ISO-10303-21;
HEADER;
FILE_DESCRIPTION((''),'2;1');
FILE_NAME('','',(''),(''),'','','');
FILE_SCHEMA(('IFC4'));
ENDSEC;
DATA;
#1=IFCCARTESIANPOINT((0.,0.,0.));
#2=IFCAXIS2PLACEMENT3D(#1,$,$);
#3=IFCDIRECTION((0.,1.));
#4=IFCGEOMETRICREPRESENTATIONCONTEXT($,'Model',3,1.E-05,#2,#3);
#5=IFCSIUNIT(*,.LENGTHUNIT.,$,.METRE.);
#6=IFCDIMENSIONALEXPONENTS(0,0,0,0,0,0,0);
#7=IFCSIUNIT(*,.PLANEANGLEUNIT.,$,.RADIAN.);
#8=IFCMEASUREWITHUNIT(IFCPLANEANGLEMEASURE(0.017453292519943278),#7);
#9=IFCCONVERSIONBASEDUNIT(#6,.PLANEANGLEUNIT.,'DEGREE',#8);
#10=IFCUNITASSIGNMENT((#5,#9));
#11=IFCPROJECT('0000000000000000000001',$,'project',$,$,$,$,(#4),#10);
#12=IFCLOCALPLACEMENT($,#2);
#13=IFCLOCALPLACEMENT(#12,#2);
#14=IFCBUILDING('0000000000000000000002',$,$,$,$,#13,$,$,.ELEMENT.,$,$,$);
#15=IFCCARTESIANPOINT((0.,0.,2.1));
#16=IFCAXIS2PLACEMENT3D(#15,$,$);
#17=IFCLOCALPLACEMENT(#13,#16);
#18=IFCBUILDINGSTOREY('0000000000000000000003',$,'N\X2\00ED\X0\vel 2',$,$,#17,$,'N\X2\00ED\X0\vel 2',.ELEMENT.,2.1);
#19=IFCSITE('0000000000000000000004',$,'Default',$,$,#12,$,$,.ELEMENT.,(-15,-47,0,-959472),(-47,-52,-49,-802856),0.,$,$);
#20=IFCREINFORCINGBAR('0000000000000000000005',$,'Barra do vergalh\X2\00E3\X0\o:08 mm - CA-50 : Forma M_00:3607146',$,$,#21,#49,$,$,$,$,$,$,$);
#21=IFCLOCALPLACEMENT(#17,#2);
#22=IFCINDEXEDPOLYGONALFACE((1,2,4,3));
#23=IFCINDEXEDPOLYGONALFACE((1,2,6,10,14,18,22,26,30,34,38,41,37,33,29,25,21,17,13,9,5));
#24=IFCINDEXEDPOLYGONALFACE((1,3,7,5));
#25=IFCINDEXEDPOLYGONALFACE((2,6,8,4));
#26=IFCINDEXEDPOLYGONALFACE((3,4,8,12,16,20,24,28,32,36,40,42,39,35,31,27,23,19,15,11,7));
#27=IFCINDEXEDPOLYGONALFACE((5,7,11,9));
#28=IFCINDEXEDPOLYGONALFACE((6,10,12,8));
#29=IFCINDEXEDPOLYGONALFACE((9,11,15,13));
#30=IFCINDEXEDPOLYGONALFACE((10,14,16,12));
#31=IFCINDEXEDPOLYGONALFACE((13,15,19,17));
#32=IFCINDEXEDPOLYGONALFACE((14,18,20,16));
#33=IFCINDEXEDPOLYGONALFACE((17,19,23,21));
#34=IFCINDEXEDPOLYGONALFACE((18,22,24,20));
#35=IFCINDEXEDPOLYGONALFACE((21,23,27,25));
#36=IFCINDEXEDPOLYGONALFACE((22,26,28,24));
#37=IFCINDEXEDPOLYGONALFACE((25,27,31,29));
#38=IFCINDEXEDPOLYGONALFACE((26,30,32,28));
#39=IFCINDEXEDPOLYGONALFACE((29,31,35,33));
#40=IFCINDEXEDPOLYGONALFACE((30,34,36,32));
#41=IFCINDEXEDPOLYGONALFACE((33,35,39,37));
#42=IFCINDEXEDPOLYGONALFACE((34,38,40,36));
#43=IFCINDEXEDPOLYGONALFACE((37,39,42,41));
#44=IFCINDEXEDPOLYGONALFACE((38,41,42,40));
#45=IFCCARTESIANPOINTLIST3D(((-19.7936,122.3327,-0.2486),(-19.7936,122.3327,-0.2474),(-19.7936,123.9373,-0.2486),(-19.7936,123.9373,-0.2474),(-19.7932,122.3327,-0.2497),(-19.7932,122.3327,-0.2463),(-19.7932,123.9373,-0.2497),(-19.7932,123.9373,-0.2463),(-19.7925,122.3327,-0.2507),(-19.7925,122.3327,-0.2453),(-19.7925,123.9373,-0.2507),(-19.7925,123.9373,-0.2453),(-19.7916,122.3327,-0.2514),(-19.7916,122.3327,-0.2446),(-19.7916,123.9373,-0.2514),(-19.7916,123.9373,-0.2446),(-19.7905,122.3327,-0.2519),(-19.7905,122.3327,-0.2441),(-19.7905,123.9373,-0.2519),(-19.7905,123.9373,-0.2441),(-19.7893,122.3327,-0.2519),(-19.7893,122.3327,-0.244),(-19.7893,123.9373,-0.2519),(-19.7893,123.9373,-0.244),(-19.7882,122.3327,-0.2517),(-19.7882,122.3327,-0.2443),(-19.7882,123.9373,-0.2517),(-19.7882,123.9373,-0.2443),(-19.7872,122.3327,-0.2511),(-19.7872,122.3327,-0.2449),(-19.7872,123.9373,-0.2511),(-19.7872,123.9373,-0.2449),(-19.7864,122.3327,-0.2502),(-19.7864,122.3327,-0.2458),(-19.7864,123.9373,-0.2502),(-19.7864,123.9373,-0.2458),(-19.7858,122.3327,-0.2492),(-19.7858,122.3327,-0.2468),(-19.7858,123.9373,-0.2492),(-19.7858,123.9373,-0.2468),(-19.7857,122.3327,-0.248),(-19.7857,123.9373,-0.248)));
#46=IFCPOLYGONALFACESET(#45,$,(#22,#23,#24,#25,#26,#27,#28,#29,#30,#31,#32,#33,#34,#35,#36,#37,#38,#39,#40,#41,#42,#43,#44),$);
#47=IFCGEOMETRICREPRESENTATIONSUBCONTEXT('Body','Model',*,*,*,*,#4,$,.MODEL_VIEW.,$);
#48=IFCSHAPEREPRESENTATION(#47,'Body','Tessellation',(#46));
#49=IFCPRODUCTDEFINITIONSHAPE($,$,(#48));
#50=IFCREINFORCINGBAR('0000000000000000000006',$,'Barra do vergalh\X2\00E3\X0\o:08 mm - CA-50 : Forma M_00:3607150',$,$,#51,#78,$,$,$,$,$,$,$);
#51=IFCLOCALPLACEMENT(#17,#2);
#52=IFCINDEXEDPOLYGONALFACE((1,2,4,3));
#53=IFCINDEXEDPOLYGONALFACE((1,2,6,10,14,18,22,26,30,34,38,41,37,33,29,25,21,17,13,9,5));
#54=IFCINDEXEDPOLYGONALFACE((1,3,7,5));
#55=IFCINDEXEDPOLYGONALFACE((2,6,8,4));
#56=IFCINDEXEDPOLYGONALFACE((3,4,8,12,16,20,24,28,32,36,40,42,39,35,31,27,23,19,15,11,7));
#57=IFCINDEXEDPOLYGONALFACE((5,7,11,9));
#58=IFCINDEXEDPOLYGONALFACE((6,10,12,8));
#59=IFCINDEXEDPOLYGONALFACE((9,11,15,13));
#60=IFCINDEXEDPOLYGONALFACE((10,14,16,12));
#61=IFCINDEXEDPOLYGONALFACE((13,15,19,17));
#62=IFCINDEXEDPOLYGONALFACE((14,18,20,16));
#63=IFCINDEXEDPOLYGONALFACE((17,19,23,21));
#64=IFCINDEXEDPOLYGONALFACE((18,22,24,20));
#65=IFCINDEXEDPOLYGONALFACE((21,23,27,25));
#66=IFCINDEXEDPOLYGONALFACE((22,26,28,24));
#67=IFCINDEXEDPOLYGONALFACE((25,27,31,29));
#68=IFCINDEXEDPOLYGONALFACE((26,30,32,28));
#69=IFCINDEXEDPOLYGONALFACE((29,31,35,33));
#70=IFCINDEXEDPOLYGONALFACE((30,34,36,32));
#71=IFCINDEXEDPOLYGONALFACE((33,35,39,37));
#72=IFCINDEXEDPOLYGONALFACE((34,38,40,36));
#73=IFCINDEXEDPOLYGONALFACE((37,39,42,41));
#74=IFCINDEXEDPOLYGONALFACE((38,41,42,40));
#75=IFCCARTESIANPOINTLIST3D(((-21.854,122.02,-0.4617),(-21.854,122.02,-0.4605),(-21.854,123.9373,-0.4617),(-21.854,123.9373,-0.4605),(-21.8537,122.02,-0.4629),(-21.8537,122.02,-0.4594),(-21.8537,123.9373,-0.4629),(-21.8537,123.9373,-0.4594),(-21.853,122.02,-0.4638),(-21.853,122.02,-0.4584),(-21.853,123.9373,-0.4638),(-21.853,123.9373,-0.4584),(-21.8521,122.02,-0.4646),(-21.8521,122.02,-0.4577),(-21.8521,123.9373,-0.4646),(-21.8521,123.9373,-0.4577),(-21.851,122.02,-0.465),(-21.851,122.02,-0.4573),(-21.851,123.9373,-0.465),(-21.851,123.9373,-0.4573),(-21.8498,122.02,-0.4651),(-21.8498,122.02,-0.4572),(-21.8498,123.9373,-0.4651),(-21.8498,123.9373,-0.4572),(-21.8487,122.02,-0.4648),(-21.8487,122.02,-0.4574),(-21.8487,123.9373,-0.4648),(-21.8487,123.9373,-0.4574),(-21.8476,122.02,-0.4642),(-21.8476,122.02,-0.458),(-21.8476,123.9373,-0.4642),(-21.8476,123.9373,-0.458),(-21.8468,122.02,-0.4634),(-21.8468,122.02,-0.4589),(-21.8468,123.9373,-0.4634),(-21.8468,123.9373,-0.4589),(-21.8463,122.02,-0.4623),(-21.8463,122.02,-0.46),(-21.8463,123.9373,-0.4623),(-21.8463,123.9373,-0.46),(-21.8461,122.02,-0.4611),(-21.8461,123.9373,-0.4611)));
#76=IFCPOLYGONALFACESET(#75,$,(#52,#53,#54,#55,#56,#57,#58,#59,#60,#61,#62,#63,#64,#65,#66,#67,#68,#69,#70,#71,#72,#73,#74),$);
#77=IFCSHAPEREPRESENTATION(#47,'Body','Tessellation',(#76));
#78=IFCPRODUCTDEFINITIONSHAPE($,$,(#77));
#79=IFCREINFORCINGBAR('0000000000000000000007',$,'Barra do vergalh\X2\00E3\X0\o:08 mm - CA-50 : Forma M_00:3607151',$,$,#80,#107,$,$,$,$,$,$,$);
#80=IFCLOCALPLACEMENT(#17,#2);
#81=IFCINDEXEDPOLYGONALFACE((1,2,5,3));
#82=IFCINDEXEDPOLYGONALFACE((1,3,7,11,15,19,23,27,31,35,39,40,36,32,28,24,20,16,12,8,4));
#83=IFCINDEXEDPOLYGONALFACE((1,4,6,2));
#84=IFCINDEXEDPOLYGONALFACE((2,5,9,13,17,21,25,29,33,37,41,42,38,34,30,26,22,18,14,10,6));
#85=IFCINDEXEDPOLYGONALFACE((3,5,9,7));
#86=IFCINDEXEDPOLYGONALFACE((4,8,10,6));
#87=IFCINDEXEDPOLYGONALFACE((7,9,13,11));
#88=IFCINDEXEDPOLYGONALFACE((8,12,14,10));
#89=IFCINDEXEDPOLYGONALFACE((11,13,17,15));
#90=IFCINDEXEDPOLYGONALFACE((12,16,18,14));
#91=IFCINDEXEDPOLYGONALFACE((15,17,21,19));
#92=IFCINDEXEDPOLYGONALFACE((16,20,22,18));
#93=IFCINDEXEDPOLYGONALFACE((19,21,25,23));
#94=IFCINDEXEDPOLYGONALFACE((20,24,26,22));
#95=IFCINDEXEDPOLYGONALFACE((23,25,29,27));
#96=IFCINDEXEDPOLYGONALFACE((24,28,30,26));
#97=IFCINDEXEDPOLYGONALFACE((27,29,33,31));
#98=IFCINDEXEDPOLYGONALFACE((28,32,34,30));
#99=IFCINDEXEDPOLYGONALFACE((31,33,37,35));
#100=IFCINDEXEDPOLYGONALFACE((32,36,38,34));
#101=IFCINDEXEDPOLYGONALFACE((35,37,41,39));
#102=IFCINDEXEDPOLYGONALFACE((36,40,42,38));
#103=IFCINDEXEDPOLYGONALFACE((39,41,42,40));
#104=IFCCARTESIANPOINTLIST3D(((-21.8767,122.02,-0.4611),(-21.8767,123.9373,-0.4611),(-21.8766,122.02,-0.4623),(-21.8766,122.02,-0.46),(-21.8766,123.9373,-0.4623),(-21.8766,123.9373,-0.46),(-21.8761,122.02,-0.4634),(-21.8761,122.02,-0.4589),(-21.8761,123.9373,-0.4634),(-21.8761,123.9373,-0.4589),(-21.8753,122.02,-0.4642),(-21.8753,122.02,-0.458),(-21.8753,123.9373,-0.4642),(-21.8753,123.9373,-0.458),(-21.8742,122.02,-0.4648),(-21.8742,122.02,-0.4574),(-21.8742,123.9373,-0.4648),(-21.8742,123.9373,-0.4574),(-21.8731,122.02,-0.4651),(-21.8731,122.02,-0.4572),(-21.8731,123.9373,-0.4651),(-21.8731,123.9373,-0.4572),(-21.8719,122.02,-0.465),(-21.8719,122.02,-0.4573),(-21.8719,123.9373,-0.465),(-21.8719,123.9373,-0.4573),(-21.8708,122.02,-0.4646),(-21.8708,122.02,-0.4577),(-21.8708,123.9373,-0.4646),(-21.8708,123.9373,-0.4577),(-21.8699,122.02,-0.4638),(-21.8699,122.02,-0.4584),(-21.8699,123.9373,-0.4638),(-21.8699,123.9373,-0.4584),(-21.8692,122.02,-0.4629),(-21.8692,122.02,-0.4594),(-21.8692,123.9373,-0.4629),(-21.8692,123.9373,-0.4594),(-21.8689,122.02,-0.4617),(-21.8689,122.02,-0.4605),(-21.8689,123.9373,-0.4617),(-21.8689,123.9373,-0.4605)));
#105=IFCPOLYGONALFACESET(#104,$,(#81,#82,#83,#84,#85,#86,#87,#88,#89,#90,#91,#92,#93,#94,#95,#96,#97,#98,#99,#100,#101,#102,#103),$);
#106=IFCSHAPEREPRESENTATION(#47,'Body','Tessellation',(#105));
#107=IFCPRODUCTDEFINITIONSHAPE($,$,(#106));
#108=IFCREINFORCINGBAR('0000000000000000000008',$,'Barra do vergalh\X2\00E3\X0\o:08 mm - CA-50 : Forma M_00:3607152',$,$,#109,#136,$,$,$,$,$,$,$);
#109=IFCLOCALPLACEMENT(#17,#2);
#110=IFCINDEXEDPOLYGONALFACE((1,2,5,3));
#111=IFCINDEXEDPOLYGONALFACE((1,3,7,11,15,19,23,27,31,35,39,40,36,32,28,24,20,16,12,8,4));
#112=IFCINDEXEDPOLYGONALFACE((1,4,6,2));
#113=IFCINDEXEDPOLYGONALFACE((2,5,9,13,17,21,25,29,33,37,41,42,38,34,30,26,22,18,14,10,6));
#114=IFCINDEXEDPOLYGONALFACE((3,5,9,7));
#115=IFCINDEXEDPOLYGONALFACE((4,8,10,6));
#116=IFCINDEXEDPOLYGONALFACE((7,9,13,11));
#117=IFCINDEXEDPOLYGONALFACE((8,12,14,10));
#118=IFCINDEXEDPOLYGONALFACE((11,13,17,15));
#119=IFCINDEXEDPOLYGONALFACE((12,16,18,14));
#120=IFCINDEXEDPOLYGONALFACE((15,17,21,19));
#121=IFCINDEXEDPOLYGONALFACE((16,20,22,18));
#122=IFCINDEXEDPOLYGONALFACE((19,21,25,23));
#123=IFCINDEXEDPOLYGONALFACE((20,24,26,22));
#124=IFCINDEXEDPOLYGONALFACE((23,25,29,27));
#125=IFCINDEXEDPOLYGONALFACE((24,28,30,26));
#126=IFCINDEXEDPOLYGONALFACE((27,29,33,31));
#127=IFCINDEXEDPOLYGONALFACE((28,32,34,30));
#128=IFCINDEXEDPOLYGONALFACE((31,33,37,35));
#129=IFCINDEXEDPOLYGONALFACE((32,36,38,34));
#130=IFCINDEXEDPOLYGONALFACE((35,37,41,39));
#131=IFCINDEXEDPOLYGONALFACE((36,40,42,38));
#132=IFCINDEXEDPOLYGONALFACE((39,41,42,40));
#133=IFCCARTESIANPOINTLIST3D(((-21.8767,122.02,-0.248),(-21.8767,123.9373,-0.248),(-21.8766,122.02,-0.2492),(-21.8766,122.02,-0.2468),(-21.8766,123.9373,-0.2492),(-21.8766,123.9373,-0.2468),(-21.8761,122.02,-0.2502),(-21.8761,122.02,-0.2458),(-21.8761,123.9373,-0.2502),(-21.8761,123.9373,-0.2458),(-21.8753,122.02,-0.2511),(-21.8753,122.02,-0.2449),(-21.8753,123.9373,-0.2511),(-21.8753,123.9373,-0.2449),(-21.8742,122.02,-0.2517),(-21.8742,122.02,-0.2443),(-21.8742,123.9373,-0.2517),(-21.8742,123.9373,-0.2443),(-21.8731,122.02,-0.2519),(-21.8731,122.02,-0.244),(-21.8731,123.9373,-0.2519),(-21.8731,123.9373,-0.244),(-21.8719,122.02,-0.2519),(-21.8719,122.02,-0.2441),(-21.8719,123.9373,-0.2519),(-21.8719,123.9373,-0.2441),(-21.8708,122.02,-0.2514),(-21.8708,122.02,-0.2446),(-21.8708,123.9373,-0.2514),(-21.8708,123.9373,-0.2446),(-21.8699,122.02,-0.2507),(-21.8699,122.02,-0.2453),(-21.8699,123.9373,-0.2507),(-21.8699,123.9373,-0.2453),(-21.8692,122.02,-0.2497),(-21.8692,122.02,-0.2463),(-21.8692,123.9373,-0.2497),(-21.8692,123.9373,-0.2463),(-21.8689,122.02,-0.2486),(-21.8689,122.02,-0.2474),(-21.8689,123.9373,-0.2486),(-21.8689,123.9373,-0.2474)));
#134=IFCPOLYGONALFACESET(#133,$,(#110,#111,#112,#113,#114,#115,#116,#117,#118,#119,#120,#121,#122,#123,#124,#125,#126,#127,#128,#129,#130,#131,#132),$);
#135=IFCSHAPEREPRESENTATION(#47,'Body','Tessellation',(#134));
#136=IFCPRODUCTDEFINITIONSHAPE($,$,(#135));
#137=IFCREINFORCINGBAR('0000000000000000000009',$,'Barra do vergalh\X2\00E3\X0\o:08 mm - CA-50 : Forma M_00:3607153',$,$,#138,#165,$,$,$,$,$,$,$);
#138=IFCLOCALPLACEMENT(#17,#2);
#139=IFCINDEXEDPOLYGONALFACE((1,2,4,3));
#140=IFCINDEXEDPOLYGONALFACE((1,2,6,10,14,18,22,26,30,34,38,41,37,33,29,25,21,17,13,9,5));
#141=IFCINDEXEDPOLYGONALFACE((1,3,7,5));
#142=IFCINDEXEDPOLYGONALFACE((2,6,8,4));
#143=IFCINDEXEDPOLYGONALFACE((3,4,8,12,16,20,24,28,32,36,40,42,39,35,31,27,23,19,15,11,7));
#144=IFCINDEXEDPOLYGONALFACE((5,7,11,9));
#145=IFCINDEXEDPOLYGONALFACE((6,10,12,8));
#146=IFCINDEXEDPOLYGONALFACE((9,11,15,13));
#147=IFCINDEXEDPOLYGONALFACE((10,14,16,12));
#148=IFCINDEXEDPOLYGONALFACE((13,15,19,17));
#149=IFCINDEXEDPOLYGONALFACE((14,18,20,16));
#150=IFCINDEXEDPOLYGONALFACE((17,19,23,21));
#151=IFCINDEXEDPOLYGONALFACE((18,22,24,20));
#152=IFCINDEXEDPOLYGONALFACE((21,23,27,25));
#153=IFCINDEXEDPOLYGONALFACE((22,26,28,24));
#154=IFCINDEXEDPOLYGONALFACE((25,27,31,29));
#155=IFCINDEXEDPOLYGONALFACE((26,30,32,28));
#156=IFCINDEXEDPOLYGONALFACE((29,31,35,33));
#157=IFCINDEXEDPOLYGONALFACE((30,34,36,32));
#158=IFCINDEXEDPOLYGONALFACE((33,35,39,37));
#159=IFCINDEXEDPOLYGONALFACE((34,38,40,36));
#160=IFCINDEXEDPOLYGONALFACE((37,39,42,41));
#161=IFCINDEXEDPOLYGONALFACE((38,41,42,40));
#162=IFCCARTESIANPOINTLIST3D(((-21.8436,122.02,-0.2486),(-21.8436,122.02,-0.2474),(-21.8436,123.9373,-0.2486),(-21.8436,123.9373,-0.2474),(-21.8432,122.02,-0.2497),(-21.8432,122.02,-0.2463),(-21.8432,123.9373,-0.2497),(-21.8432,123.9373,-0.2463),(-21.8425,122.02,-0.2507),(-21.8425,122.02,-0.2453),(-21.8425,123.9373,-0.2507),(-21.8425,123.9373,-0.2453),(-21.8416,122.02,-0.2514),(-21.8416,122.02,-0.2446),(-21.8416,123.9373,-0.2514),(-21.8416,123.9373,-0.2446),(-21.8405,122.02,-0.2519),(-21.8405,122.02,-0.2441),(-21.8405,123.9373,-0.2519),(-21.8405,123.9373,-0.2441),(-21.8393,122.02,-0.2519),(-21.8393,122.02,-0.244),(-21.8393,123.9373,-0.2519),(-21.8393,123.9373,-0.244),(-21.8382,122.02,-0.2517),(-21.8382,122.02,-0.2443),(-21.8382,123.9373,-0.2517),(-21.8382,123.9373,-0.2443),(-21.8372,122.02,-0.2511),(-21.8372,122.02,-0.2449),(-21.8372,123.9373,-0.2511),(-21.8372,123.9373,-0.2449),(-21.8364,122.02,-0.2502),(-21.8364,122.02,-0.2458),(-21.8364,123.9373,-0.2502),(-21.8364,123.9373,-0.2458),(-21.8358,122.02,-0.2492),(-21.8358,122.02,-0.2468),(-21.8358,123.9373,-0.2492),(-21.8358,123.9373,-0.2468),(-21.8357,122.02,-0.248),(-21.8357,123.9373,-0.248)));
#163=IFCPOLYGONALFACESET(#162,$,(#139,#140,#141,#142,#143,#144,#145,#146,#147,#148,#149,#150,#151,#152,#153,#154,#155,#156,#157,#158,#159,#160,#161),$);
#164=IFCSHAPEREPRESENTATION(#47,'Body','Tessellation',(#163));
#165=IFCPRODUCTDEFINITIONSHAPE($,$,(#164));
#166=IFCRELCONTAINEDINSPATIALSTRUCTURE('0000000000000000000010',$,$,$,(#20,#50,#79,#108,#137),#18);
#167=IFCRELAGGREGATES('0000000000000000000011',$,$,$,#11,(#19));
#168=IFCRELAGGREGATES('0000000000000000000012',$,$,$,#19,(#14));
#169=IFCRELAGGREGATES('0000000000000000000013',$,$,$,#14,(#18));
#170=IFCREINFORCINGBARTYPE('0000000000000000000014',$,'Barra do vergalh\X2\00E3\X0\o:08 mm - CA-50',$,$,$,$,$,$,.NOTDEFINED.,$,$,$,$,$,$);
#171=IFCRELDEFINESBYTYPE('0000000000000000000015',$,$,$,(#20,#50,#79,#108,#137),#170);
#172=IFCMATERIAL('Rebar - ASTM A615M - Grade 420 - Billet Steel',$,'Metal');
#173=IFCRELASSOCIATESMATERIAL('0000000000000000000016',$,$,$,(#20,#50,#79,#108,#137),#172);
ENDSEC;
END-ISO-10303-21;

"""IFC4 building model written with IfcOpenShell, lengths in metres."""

from ifc_helpers import new_model, entity, si_unit, converted_unit, direction, frame, origin, place, context, subcontext, project, spatial, material, type_object, element, save


model = new_model("IFC4")

# Units and contexts
model_context = context("Model", 3, precision=1e-05, world=origin(), true_north=direction((0.0, 1.0)))
body_context = subcontext(model_context, "Body", "Model", "MODEL_VIEW")
ifc_project = project(units=[si_unit("LENGTHUNIT", "METRE"), converted_unit("PLANEANGLEUNIT", "DEGREE", entity("IfcPlaneAngleMeasure", 0.017453292519943278), si_unit("PLANEANGLEUNIT", "RADIAN"), dimensions=[0, 0, 0, 0, 0, 0, 0])], contexts=[model_context])

# Site, building, storey
site_placement = place(None, origin())
site = spatial("IfcSite", under=ifc_project, at=site_placement, Name="Default", CompositionType="ELEMENT", RefLatitude=(-15, -47, 0, -959472), RefLongitude=(-47, -52, -49, -802856), RefElevation=0.0)
building_placement = place(site_placement, origin())
building = spatial("IfcBuilding", under=site, at=building_placement, CompositionType="ELEMENT")
storey_placement = place(building_placement, frame((0.0, 0.0, 2.1)))
storey = spatial("IfcBuildingStorey", under=building, at=storey_placement, Name="Nível 2", LongName="Nível 2", CompositionType="ELEMENT", Elevation=2.1)

# Reinforcing bars
ifc_material_1 = material(Name="Rebar - ASTM A615M - Grade 420 - Billet Steel", Category="Metal")
reinforcing_bar_type_1 = type_object("IfcReinforcingBarType", Name="Barra do vergalhão:08 mm - CA-50", PredefinedType="NOTDEFINED")
reinforcing_bar_1_placement = place(storey_placement, origin())
element("IfcReinforcingBar", 1, at=reinforcing_bar_1_placement, inside=storey, type_object=reinforcing_bar_type_1, material=ifc_material_1, Name="Barra do vergalhão:08 mm - CA-50 : Forma M_00:3607146", context=body_context, shape_type="AdvancedSweptSolid", body=[
    entity("IfcSweptDiskSolid", entity("IfcIndexedPolyCurve", entity("IfcCartesianPointList3D", [[19.7896, -123.9373, 0.248], [19.7896, -122.3327, 0.248]]), None, False), 0.004, None, 0.0, 1.0),
])
reinforcing_bar_2_placement = place(storey_placement, origin())
element("IfcReinforcingBar", 2, at=reinforcing_bar_2_placement, inside=storey, type_object=reinforcing_bar_type_1, material=ifc_material_1, Name="Barra do vergalhão:08 mm - CA-50 : Forma M_00:3607150", context=body_context, shape_type="AdvancedSweptSolid", body=[
    entity("IfcSweptDiskSolid", entity("IfcIndexedPolyCurve", entity("IfcCartesianPointList3D", [[21.8501, -123.9373, 0.4611], [21.8501, -122.02, 0.4611]]), None, False), 0.004, None, 0.0, 1.0),
])
reinforcing_bar_3_placement = place(storey_placement, origin())
element("IfcReinforcingBar", 3, at=reinforcing_bar_3_placement, inside=storey, type_object=reinforcing_bar_type_1, material=ifc_material_1, Name="Barra do vergalhão:08 mm - CA-50 : Forma M_00:3607151", context=body_context, shape_type="AdvancedSweptSolid", body=[
    entity("IfcSweptDiskSolid", entity("IfcIndexedPolyCurve", entity("IfcCartesianPointList3D", [[21.8728, -122.02, 0.4611], [21.8728, -123.9373, 0.4611]]), None, False), 0.004, None, 0.0, 1.0),
])
reinforcing_bar_4_placement = place(storey_placement, origin())
element("IfcReinforcingBar", 4, at=reinforcing_bar_4_placement, inside=storey, type_object=reinforcing_bar_type_1, material=ifc_material_1, Name="Barra do vergalhão:08 mm - CA-50 : Forma M_00:3607152", context=body_context, shape_type="AdvancedSweptSolid", body=[
    entity("IfcSweptDiskSolid", entity("IfcIndexedPolyCurve", entity("IfcCartesianPointList3D", [[21.8728, -122.02, 0.248], [21.8728, -123.9373, 0.248]]), None, False), 0.004, None, 0.0, 1.0),
])
reinforcing_bar_5_placement = place(storey_placement, origin())
element("IfcReinforcingBar", 5, at=reinforcing_bar_5_placement, inside=storey, type_object=reinforcing_bar_type_1, material=ifc_material_1, Name="Barra do vergalhão:08 mm - CA-50 : Forma M_00:3607153", context=body_context, shape_type="AdvancedSweptSolid", body=[
    entity("IfcSweptDiskSolid", entity("IfcIndexedPolyCurve", entity("IfcCartesianPointList3D", [[21.8396, -123.9373, 0.248], [21.8396, -122.02, 0.248]]), None, False), 0.004, None, 0.0, 1.0),
])

save(model, "model.ifc")
